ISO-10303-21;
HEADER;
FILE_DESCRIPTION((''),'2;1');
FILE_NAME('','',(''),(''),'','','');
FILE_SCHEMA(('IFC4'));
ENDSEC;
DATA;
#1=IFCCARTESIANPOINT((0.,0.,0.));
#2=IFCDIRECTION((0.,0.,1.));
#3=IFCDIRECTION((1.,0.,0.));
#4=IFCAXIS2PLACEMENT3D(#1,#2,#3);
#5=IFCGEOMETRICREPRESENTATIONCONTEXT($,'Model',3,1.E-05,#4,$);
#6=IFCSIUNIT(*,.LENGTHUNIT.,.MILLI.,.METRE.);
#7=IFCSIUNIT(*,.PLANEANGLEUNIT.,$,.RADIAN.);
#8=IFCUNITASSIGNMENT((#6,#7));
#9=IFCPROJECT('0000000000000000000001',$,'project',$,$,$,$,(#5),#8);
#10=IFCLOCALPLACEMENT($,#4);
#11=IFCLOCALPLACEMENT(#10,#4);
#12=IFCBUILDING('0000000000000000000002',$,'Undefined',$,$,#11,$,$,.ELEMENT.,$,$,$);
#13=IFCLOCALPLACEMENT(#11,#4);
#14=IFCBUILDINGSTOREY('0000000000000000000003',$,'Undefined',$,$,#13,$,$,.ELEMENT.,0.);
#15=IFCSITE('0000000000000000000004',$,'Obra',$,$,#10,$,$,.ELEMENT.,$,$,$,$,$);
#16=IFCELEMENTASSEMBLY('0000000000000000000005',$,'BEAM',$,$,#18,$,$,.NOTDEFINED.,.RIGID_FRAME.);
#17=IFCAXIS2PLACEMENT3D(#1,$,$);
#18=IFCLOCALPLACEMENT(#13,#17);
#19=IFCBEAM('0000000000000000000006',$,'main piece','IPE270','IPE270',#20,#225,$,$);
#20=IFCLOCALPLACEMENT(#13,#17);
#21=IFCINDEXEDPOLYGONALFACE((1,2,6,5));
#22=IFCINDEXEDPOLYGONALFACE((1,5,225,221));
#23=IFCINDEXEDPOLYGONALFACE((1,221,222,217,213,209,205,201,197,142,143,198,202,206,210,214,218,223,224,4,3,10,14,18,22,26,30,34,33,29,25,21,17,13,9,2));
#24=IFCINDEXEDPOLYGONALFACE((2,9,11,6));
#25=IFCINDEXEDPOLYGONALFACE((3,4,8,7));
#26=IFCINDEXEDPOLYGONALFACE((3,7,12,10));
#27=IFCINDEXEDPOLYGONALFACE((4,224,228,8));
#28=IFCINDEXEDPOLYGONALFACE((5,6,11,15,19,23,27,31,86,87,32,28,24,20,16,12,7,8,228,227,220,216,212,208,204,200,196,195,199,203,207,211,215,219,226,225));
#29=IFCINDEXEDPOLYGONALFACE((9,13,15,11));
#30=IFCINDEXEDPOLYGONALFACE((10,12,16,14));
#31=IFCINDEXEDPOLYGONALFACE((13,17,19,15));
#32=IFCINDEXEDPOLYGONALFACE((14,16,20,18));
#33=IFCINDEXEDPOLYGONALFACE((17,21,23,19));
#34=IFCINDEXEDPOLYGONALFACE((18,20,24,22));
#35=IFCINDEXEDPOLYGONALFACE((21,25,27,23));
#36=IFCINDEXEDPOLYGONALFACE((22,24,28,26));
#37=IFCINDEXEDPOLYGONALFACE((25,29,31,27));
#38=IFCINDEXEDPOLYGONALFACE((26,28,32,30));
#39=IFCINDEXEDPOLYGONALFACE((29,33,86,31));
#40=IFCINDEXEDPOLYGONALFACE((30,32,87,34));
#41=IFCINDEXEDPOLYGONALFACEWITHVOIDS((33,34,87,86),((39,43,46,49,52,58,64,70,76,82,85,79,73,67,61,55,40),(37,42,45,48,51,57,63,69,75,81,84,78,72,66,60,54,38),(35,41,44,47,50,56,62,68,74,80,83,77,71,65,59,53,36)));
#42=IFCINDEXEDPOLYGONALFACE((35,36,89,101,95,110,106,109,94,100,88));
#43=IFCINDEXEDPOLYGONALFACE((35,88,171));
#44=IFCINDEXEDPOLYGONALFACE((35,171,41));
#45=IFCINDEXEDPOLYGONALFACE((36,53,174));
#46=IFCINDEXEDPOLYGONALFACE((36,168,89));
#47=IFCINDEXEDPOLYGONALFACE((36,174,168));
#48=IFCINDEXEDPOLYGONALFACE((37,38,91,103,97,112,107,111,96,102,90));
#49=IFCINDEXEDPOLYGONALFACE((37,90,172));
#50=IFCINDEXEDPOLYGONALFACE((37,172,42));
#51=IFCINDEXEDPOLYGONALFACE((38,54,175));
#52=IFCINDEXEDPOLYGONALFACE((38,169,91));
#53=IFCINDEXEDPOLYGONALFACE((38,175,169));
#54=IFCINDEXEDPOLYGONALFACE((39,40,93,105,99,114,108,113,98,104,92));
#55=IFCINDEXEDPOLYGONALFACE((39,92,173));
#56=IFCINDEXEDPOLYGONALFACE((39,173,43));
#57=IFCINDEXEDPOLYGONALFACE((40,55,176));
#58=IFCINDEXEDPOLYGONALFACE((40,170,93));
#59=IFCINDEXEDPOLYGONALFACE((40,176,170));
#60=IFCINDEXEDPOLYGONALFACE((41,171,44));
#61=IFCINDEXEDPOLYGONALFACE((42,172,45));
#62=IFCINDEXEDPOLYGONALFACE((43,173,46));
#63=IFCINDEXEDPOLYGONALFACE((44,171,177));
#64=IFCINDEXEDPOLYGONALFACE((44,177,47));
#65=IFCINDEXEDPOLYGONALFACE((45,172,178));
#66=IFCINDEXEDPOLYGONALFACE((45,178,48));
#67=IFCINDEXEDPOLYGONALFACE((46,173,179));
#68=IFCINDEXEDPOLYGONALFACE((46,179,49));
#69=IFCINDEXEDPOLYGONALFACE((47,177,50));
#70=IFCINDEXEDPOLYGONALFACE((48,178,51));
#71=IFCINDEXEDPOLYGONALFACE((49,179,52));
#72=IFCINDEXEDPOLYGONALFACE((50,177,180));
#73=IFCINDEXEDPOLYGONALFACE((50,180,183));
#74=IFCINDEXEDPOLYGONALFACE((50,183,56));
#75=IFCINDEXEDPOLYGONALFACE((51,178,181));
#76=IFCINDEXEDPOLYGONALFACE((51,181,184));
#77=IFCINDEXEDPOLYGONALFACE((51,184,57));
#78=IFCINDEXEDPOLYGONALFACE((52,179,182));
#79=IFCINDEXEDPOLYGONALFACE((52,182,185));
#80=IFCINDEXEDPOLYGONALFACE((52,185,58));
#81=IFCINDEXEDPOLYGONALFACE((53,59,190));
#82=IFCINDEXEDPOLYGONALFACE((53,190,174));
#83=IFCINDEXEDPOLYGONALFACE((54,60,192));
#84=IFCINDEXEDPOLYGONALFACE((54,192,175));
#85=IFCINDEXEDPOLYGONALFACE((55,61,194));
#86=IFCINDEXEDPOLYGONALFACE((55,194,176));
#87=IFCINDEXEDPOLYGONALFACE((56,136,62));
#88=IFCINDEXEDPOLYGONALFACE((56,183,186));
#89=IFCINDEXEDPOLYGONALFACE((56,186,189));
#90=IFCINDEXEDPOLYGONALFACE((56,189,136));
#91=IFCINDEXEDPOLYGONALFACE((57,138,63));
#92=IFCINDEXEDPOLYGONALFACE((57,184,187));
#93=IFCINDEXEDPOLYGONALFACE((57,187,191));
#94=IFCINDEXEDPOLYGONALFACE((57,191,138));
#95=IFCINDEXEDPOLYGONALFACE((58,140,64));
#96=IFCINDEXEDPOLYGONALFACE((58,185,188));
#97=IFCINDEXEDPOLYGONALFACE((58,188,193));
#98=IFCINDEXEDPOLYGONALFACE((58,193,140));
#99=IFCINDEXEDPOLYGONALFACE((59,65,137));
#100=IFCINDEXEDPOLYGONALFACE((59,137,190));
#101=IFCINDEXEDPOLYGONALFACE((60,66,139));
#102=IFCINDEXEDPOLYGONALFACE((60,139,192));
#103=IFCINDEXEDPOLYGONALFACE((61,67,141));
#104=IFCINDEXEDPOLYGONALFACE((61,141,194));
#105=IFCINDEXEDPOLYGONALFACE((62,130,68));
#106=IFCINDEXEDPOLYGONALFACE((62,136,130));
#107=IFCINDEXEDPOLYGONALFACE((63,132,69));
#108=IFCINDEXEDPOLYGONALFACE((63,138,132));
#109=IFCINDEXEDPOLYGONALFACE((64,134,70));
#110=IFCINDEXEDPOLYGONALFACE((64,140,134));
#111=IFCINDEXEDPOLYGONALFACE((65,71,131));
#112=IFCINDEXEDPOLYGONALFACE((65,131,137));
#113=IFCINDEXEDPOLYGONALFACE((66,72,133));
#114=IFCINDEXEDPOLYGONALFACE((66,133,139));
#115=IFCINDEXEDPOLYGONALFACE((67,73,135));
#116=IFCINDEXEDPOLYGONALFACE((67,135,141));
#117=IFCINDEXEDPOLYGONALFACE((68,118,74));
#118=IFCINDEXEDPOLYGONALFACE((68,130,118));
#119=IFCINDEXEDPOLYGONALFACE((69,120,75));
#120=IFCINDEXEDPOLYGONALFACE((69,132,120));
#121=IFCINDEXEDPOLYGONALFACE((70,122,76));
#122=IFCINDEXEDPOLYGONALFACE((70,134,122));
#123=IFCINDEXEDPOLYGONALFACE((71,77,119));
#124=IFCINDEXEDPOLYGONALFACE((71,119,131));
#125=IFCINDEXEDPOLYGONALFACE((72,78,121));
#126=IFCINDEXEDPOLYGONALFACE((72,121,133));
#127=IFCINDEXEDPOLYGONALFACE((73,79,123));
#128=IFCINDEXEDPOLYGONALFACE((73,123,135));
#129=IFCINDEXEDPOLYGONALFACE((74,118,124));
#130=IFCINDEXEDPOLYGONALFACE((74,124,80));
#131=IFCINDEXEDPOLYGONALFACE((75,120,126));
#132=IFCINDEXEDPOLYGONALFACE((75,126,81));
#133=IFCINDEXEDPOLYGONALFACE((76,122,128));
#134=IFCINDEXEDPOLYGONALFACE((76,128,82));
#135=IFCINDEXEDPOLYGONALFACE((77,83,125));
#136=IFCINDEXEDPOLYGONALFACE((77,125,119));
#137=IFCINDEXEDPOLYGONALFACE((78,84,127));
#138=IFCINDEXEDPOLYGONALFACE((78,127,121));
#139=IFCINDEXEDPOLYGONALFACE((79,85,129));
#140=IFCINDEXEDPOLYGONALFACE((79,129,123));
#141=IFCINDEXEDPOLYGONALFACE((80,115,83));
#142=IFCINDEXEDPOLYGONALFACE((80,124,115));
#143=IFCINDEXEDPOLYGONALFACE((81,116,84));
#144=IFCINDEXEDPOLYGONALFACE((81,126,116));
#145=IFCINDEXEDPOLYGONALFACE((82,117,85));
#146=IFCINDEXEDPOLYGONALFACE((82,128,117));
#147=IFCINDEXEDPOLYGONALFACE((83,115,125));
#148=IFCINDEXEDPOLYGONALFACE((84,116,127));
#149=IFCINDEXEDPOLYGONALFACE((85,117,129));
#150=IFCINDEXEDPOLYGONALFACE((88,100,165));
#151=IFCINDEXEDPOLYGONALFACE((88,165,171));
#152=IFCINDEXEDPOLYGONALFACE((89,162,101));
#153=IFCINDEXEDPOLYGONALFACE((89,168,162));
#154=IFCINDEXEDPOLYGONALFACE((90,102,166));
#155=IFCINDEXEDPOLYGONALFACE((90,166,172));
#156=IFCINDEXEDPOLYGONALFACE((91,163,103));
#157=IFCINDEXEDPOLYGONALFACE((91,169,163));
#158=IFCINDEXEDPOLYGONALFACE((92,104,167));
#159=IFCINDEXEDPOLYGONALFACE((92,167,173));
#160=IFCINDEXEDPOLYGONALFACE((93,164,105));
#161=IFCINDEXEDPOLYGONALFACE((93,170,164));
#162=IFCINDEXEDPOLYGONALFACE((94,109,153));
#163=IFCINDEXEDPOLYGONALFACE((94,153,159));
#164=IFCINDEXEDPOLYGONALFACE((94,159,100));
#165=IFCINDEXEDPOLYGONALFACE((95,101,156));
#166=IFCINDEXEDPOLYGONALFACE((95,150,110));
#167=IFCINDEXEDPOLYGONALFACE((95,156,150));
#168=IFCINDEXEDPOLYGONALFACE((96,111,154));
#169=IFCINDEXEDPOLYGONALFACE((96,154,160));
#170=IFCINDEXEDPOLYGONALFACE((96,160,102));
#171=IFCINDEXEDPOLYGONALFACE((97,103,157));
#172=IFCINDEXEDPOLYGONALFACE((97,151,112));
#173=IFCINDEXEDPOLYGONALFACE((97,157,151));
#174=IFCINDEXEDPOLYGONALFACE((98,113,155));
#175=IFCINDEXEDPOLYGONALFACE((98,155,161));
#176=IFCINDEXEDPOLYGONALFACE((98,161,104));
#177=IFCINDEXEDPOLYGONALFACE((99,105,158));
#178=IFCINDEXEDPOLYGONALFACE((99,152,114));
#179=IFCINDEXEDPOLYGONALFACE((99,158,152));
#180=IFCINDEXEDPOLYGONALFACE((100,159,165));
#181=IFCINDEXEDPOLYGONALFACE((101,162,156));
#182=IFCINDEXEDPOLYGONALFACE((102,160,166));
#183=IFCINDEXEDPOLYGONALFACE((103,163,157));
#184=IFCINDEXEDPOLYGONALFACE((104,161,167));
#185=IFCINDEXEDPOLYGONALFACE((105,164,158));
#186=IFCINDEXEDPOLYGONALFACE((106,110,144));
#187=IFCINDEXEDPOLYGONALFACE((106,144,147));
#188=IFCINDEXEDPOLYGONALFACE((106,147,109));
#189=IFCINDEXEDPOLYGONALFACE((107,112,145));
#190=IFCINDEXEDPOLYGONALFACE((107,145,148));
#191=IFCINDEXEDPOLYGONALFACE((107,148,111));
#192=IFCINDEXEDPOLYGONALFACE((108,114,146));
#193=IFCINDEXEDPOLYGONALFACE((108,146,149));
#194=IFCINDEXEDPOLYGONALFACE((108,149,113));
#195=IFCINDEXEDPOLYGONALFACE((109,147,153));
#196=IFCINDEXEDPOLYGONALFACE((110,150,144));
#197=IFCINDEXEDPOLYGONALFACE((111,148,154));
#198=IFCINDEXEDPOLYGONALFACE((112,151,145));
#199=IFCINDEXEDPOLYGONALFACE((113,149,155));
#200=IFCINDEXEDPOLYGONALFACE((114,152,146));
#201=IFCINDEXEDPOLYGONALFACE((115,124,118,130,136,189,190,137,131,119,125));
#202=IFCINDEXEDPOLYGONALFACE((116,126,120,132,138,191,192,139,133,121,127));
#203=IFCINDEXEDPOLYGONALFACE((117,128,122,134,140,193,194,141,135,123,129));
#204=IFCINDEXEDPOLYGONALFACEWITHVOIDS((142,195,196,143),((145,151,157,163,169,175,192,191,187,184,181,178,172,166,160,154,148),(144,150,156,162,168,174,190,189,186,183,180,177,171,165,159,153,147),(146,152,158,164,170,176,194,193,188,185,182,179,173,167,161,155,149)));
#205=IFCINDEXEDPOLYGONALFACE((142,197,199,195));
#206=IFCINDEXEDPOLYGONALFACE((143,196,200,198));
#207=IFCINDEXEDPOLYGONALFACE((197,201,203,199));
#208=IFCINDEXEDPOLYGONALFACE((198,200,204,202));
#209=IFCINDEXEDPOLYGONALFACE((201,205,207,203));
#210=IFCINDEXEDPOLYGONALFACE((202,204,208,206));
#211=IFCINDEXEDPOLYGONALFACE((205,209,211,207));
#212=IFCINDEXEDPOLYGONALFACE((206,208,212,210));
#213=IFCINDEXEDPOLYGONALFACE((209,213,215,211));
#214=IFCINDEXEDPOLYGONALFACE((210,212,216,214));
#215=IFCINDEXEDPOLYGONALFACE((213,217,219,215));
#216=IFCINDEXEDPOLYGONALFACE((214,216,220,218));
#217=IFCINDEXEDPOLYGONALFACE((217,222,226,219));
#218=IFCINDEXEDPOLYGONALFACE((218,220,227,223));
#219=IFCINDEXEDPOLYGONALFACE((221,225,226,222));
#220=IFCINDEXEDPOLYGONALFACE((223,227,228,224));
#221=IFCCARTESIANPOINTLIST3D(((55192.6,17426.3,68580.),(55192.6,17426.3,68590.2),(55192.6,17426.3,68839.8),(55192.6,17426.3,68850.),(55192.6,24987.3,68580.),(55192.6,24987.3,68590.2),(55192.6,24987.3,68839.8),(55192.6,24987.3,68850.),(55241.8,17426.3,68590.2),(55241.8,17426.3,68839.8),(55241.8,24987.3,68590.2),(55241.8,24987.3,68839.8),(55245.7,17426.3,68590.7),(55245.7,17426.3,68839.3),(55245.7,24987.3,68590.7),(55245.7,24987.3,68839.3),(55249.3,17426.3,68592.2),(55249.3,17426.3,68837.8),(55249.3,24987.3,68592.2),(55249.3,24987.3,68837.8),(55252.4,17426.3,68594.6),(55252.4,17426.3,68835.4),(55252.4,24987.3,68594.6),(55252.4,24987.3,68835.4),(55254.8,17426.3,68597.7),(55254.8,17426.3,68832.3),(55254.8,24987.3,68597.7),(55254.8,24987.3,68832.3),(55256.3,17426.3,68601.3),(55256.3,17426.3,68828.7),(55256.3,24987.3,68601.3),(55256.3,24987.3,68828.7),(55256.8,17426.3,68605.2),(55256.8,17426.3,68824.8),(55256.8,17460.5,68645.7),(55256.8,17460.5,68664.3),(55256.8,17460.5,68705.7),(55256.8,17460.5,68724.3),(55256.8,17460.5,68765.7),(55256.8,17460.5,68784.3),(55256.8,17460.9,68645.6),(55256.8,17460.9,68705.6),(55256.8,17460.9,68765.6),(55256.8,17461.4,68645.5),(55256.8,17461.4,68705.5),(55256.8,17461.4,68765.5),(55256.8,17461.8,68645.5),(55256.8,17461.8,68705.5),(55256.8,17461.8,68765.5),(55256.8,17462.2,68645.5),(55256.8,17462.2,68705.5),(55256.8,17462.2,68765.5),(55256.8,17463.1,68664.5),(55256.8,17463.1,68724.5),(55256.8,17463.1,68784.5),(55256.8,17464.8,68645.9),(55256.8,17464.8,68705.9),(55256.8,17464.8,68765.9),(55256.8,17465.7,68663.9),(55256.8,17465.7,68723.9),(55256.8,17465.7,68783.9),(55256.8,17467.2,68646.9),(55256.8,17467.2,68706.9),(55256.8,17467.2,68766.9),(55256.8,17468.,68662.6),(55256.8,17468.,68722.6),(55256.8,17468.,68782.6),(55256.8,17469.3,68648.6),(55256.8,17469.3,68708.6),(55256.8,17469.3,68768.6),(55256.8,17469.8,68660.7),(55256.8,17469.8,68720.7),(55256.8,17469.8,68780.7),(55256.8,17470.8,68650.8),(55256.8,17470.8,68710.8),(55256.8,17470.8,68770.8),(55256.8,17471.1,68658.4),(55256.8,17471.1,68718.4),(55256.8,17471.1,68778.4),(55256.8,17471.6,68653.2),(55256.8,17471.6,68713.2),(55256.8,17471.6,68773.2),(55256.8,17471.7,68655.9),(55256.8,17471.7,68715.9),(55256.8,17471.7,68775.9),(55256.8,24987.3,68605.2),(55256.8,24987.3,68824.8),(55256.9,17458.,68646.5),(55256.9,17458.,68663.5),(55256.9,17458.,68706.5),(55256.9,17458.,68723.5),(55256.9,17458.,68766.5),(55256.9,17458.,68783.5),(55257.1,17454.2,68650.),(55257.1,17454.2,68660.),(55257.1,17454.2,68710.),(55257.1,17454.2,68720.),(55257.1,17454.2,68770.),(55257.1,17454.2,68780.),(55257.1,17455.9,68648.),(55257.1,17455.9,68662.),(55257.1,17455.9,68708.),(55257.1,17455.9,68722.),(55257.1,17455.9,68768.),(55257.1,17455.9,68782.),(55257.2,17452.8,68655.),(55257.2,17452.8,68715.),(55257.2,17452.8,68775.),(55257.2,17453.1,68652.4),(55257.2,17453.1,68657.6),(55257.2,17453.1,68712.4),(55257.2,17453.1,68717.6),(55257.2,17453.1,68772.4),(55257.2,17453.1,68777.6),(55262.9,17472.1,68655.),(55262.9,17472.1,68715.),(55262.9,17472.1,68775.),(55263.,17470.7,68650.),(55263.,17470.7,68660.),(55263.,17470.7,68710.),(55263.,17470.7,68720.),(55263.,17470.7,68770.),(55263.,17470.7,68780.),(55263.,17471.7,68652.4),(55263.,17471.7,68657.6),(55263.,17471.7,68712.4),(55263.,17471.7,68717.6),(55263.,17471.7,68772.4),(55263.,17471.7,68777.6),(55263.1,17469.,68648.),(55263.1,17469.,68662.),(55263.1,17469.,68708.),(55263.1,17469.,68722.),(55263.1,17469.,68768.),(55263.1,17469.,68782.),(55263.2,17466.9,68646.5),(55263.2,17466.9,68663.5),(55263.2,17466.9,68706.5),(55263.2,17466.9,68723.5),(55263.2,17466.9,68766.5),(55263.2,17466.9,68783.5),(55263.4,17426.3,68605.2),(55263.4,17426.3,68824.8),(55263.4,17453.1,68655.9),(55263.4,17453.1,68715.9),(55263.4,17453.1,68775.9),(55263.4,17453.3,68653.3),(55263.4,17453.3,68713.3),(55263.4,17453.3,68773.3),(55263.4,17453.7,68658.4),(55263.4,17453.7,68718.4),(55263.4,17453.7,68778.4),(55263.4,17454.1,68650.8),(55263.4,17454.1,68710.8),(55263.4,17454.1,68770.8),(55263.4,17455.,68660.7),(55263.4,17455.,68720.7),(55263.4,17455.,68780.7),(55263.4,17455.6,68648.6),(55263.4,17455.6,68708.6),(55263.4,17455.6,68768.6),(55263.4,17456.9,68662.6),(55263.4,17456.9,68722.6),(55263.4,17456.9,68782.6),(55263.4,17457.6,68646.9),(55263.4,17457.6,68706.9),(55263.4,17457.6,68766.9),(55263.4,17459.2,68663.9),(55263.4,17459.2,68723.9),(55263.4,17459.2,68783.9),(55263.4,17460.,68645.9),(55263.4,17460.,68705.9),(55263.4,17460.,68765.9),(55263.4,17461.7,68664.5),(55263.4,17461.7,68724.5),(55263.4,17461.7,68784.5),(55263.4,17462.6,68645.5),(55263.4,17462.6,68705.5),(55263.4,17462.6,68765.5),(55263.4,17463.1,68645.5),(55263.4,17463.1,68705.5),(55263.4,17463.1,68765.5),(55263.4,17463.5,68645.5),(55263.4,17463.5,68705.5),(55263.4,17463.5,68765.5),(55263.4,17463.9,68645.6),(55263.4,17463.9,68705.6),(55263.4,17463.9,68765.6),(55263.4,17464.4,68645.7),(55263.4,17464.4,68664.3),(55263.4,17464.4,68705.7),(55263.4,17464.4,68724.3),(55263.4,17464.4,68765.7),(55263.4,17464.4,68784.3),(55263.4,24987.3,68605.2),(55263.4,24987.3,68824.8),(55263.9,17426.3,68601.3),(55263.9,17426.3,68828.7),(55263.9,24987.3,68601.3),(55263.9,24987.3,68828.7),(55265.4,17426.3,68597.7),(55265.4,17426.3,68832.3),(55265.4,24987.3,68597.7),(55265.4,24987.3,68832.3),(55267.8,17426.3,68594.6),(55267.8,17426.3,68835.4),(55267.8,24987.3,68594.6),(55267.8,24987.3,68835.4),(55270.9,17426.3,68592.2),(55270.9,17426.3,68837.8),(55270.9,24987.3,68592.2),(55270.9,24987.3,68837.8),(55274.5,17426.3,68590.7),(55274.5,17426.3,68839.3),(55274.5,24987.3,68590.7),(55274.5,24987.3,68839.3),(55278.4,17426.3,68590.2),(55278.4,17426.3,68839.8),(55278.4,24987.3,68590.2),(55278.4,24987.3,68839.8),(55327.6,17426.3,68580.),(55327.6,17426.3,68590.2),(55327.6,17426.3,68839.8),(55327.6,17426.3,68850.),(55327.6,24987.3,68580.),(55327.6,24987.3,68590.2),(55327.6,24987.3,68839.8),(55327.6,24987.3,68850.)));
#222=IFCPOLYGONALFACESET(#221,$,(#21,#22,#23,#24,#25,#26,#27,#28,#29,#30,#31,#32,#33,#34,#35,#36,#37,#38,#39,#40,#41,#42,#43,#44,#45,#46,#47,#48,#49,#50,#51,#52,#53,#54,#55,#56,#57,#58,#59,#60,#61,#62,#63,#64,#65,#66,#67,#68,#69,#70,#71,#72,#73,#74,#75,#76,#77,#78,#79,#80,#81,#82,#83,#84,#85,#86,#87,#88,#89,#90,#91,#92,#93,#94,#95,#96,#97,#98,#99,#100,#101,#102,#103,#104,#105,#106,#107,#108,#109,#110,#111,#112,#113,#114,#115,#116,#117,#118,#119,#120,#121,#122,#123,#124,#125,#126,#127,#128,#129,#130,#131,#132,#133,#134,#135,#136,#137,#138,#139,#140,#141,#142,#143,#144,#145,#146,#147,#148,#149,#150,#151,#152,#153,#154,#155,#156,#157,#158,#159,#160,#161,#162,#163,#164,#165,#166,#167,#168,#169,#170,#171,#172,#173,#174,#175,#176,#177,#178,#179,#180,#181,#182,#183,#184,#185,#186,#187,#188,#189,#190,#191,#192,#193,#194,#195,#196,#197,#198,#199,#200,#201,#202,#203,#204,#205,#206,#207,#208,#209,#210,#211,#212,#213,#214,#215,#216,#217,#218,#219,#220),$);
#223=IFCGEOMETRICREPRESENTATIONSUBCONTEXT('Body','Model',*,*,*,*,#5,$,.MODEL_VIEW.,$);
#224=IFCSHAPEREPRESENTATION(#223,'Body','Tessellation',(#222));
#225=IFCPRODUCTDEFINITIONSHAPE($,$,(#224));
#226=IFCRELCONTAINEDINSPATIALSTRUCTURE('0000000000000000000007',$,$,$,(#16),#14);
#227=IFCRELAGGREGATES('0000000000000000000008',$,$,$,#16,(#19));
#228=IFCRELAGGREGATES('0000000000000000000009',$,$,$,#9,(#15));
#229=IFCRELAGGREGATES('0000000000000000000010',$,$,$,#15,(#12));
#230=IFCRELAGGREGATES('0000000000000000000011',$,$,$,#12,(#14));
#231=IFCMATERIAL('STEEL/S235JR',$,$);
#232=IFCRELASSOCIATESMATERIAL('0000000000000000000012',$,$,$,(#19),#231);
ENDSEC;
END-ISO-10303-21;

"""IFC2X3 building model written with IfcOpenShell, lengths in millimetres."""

from ifc_helpers import new_model, si_unit, frame, origin_with_axes, origin_2d_with_axis, place, context, subcontext, project, spatial, circle, i_section, extrude, clip, halfspace, source, transform, mapped, material, element, aggregate, save


model = new_model("IFC2X3")

# Units and contexts
model_context = context("Model", 3, precision=1e-05, world=origin_with_axes())
body_context = subcontext(model_context, "Body", "Model", "MODEL_VIEW")
ifc_project = project(units=[si_unit("LENGTHUNIT", "METRE", prefix="MILLI"), si_unit("PLANEANGLEUNIT", "RADIAN")], contexts=[model_context])

# Site, building, storey
site_placement = place(None, origin_with_axes())
site = spatial("IfcSite", under=ifc_project, at=site_placement, Name="Obra", CompositionType="ELEMENT")
building_placement = place(site_placement, origin_with_axes())
building = spatial("IfcBuilding", under=site, at=building_placement, Name="Undefined", CompositionType="ELEMENT")
storey_placement = place(building_placement, origin_with_axes())
storey = spatial("IfcBuildingStorey", under=building, at=storey_placement, Name="Undefined", CompositionType="ELEMENT", Elevation=0.0)

# Shared definitions
ifc_material_1 = material(Name="STEEL/S235JR")

# Element assembly, beam, opening
shared_shape_1 = source(origin_with_axes(), body_context, "Body", "SweptSolid", [
    extrude(circle(Radius=9.5, at=origin_2d_with_axis()), frame((0.0, -35.4, 0.0), z_axis=(0.0, 1.0, 0.0), x_axis=(1.0, 0.0, 0.0)), (0.0, 0.0, 1.0), 6.8),
])
assembly_1_placement = place(storey_placement, origin_with_axes())
assembly_1 = element("IfcElementAssembly", 1, at=assembly_1_placement, inside=storey, Name="BEAM", AssemblyPlace="NOTDEFINED", PredefinedType="RIGID_FRAME")
beam_1_placement = place(assembly_1_placement, frame((55260.1, 24987.3, 68715.0), z_axis=(0.0, 0.0, 1.0), x_axis=(0.0, -1.0, 0.0)))
beam_1 = element("IfcBeam", 2, at=beam_1_placement, material=ifc_material_1, Name="main piece", Description="IPE270", ObjectType="IPE270", context=body_context, shape_type="Clipping", body=[
    clip(extrude(i_section(OverallWidth=135.0, OverallDepth=270.0, WebThickness=6.6, FlangeThickness=10.2, FilletRadius=15.0, at=origin_2d_with_axis()), frame((7560.9, 0.0, 0.0), z_axis=(-1.0, 0.0, 0.0), x_axis=(0.0, -1.0, 0.0)), (0.0, 0.0, 1.0), 7560.9), halfspace(frame((7579.6, -89.1, -120.0), z_axis=(0.998367, 0.057126, 0.0), x_axis=(0.0, 0.0, 1.0)), False)),
])
opening_1_placement = place(assembly_1_placement, frame((55231.0, 17410.7, 68835.0), z_axis=(-0.057107, 0.998368, 0.0), x_axis=(0.0, 0.0, -1.0)))
element("IfcOpeningElement", 3, at=opening_1_placement, cuts=beam_1, ObjectType="Opening", context=body_context, shape_type="MappedRepresentation", body=[
    mapped(shared_shape_1, transform((60.0, 0.0, 50.0))),
    mapped(shared_shape_1, transform((120.0, 0.0, 50.0))),
    mapped(shared_shape_1, transform((180.0, 0.0, 50.0))),
])
aggregate(assembly_1, [beam_1])

save(model, "model.ifc")
